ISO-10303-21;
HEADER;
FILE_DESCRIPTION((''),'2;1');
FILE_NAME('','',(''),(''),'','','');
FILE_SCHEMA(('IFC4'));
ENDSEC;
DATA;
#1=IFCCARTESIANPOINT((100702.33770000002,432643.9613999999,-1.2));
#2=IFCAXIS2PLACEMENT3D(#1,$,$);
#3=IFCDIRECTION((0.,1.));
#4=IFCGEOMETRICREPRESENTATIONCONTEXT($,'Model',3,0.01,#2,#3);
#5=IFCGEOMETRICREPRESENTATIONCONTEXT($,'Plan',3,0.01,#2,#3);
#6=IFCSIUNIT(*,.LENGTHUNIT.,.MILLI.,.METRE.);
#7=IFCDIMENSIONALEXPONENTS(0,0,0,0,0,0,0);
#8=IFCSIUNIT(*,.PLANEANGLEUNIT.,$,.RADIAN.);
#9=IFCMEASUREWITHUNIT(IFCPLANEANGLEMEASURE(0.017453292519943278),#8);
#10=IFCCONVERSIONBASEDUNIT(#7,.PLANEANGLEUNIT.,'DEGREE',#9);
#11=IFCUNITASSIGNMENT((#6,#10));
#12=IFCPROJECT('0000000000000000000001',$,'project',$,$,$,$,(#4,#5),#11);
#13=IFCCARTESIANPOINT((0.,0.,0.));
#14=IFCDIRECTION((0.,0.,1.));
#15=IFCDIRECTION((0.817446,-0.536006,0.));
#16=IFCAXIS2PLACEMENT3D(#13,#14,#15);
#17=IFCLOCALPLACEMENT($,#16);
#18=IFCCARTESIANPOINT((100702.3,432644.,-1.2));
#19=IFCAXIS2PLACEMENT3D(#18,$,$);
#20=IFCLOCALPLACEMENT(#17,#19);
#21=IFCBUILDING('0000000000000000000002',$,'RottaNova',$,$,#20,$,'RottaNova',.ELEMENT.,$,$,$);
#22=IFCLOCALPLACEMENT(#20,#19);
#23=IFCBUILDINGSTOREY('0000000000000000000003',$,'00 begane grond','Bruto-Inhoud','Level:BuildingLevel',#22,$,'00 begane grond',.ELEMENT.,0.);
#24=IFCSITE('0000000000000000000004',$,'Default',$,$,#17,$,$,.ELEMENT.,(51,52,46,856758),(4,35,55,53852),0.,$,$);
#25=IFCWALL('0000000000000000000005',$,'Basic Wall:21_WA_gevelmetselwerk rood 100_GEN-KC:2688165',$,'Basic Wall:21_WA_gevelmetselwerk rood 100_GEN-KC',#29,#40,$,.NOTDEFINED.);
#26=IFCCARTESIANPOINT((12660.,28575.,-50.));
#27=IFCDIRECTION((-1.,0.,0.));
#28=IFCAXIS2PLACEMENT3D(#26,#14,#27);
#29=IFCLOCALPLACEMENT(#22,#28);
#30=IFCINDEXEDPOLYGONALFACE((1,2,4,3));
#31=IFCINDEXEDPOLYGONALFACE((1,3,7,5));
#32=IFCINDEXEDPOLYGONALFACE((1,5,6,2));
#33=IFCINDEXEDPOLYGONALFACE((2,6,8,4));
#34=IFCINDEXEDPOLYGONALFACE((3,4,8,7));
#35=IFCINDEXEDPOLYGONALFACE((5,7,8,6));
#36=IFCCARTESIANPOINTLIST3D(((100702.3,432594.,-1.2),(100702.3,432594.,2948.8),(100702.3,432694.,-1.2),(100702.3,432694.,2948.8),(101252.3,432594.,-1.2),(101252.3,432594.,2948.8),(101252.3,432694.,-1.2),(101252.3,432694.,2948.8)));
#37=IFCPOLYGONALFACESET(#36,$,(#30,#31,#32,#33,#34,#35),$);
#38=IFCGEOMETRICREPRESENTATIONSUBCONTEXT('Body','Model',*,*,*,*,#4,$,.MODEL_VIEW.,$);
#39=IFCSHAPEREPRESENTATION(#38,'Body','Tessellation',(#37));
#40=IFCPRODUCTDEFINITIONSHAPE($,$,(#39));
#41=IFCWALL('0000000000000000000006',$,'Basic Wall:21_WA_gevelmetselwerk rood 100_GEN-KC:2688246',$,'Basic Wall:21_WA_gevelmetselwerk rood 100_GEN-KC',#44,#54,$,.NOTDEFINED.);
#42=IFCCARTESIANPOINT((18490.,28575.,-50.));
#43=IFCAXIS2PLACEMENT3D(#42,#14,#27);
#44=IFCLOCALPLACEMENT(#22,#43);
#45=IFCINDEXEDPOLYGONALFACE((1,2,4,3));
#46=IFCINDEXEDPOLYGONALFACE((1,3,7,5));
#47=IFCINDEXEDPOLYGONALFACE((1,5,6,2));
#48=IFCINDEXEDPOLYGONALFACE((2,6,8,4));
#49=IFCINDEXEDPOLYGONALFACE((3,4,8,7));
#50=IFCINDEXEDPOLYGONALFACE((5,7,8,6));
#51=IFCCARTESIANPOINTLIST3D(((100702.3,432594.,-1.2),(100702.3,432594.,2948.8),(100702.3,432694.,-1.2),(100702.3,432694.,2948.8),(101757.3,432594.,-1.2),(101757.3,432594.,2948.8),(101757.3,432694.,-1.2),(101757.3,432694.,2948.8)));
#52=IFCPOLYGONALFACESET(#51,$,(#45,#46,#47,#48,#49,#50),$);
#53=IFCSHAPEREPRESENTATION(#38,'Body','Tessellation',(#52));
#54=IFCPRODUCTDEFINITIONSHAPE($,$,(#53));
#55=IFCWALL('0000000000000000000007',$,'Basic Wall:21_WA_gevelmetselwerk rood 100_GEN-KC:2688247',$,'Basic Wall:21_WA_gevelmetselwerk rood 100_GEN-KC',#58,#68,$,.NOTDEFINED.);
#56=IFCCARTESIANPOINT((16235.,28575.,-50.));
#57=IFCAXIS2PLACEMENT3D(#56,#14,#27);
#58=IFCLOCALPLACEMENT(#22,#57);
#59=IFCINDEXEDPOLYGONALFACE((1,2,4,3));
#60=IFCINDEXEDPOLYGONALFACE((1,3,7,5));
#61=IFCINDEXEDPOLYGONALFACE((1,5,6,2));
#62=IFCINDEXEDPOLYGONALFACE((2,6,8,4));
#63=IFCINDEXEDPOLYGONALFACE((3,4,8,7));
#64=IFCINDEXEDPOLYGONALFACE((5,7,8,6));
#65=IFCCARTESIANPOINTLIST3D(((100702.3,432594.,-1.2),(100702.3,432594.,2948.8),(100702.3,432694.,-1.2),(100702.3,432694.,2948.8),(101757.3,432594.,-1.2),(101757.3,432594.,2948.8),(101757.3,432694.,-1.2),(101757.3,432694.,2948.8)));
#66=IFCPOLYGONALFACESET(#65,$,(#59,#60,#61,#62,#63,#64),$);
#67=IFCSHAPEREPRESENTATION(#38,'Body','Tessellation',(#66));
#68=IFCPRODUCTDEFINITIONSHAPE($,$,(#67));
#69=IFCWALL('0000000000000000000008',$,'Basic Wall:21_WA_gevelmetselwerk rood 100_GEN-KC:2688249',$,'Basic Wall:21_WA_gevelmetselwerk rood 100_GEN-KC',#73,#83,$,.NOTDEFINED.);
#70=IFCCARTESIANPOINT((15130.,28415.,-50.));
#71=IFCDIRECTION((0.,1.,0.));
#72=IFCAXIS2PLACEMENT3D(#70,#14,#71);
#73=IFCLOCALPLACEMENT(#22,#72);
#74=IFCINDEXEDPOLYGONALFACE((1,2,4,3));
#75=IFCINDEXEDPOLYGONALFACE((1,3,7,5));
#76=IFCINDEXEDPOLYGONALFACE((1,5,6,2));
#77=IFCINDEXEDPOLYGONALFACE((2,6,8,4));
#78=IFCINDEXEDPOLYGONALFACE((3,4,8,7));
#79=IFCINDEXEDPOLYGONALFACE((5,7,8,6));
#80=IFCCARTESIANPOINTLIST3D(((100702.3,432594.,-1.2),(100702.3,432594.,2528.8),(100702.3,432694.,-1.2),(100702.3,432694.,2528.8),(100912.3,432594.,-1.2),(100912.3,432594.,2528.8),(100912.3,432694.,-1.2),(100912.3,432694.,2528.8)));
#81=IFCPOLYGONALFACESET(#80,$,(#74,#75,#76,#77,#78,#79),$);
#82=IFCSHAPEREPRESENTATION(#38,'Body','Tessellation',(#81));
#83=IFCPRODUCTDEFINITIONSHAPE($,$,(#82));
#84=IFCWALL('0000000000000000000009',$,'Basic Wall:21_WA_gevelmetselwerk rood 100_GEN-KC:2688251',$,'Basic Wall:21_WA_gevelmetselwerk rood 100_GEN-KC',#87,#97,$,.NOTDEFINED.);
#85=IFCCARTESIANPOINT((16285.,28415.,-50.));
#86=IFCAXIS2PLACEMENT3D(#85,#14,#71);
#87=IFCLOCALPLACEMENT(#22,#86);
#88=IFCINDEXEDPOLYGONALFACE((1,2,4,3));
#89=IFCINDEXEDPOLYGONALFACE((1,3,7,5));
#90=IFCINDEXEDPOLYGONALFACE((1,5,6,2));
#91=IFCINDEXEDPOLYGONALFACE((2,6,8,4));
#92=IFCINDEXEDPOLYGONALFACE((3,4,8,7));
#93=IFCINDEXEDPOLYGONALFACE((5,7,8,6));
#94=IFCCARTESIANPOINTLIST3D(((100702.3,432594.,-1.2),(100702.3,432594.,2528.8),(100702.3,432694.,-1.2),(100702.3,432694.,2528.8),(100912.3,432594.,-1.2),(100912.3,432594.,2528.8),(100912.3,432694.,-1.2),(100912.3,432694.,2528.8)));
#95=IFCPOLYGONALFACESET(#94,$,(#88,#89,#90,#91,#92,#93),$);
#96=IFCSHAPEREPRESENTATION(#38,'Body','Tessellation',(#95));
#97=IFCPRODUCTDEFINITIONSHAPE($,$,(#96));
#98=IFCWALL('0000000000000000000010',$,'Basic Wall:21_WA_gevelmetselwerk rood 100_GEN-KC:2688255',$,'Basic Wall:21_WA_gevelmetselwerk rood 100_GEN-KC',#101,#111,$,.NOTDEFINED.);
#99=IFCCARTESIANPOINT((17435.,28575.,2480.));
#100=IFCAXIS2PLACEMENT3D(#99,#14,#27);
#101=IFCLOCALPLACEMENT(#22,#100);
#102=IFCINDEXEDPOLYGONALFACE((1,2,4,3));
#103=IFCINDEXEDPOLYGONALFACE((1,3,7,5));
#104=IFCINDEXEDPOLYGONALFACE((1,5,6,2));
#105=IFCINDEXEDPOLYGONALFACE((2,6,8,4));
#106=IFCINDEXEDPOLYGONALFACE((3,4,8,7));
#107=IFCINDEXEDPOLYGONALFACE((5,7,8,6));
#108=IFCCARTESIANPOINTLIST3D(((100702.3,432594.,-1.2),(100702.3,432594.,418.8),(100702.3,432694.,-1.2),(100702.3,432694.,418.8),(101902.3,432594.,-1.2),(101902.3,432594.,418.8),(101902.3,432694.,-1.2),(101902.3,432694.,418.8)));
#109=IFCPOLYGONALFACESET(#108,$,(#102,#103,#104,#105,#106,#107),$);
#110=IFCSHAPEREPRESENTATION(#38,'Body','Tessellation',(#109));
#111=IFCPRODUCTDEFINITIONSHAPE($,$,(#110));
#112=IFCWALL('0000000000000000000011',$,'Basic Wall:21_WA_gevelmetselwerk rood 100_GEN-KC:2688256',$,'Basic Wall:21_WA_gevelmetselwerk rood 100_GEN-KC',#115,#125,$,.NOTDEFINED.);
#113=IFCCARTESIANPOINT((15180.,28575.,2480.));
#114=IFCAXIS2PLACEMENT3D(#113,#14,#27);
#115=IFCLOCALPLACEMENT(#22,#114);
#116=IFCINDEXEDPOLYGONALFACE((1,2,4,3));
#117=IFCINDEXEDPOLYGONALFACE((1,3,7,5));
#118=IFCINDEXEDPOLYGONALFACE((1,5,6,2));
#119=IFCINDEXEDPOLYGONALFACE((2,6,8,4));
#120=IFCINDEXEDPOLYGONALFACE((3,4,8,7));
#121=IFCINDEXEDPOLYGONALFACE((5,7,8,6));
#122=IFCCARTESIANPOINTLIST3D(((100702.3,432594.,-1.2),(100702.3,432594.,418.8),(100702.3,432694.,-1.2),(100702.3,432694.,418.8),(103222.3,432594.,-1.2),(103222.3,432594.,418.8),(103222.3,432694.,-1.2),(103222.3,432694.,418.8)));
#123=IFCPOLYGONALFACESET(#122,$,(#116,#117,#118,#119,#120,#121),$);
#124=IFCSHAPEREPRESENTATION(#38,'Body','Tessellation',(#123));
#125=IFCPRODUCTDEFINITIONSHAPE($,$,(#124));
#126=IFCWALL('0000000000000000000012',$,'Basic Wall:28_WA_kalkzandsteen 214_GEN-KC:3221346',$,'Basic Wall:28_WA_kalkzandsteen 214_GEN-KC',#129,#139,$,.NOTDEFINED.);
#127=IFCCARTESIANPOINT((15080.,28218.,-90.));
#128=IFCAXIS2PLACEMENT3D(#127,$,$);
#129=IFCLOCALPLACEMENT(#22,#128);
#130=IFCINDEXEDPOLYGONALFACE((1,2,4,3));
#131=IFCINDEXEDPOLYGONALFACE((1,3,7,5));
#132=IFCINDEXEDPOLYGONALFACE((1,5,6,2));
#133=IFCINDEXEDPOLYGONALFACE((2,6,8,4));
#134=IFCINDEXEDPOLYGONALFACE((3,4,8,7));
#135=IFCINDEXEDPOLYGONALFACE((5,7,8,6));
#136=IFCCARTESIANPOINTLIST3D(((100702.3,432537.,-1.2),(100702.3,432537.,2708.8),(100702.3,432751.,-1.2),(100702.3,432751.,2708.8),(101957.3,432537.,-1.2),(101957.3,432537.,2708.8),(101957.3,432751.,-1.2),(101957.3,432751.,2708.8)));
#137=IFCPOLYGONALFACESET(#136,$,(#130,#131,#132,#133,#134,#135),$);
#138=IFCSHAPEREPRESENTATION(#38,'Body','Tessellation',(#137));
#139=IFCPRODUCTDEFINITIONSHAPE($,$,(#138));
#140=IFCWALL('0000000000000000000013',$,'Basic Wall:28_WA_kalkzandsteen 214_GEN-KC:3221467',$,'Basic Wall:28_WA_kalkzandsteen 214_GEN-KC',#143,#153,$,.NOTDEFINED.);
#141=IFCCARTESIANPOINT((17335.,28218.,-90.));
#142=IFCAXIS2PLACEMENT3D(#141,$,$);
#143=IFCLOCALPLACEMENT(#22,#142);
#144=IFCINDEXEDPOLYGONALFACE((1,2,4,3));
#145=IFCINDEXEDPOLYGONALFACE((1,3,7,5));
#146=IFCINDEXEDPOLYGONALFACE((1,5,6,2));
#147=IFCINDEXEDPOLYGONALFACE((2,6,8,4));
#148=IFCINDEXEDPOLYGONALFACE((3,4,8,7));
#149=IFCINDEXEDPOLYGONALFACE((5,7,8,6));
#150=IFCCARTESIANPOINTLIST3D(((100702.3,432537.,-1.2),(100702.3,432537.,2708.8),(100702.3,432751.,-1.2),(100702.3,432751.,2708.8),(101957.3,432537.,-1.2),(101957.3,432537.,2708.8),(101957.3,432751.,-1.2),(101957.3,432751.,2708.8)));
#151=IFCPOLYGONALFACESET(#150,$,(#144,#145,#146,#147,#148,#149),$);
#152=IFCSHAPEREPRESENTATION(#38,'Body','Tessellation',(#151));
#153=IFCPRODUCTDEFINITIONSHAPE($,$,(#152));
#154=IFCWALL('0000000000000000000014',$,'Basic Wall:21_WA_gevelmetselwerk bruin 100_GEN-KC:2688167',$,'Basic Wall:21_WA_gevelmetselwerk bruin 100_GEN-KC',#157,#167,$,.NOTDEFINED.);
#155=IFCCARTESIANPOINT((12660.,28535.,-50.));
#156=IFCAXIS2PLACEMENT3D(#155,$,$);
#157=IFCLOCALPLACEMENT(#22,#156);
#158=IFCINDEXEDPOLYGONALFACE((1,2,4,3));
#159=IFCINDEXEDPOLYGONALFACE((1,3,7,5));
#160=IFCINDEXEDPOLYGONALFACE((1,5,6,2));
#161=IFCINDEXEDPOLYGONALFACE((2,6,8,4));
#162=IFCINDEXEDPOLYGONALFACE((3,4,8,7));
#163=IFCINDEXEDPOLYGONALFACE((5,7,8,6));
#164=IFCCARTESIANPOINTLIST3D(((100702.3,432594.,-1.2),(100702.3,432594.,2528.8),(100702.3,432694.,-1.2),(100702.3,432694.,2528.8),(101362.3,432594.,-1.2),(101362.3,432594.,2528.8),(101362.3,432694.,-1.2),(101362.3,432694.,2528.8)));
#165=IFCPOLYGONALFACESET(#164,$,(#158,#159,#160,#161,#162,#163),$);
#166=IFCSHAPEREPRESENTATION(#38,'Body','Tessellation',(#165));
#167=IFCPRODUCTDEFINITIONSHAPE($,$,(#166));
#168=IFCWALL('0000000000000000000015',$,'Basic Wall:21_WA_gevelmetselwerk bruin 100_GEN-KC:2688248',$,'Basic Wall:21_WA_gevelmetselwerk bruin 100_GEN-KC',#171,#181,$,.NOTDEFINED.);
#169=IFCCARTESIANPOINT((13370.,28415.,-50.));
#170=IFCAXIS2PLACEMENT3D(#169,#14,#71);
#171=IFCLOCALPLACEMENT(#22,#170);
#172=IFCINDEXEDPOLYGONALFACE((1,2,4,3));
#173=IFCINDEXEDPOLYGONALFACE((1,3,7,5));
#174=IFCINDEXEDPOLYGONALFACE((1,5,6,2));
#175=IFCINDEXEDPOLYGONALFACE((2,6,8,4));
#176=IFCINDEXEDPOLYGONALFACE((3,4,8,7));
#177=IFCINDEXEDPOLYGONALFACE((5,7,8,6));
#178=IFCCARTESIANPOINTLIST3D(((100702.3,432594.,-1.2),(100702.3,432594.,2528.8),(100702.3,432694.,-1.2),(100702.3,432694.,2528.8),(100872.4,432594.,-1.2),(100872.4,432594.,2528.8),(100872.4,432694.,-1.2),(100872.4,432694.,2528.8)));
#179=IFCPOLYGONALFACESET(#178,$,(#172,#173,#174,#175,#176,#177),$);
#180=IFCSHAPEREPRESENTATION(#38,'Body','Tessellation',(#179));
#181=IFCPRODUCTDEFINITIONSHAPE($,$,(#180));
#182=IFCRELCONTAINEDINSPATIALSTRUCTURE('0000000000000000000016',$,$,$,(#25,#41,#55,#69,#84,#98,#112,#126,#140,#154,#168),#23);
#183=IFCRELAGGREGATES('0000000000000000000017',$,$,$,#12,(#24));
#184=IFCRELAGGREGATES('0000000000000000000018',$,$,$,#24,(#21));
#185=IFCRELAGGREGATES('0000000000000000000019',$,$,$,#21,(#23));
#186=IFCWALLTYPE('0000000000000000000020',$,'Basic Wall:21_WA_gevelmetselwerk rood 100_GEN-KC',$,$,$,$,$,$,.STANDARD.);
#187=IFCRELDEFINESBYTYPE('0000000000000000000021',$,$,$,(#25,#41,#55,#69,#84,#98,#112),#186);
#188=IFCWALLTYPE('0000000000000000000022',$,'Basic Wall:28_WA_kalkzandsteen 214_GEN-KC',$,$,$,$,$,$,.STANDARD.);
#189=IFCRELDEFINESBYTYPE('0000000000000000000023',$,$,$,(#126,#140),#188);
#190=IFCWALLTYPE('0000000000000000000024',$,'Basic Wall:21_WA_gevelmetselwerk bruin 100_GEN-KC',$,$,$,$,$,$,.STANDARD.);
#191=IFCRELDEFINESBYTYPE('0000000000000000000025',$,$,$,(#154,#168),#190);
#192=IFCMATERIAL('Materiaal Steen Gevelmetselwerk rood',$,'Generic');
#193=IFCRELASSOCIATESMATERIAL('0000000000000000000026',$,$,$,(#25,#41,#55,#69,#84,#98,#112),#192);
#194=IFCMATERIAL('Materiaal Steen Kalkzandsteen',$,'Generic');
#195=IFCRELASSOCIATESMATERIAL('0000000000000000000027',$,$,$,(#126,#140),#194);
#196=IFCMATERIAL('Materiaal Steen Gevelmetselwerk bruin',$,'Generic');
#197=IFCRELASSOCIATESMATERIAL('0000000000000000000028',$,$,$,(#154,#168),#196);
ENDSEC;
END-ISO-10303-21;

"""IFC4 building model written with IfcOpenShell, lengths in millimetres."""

from ifc_helpers import new_model, entity, si_unit, converted_unit, direction, frame, place, context, subcontext, project, spatial, indexed_curve, outline, extrude, material, type_object, element, save


model = new_model("IFC4")

# Units and contexts
model_context = context("Model", 3, precision=0.01, world=frame((100702.33770000002, 432643.9613999999, -1.2)), true_north=direction((0.0, 1.0)))
plan_context = context("Plan", 3, precision=0.01, world=frame((100702.33770000002, 432643.9613999999, -1.2)), true_north=direction((0.0, 1.0)))
body_context = subcontext(model_context, "Body", "Model", "MODEL_VIEW")
ifc_project = project(units=[si_unit("LENGTHUNIT", "METRE", prefix="MILLI"), converted_unit("PLANEANGLEUNIT", "DEGREE", entity("IfcPlaneAngleMeasure", 0.017453292519943278), si_unit("PLANEANGLEUNIT", "RADIAN"), dimensions=[0, 0, 0, 0, 0, 0, 0])], contexts=[model_context, plan_context])

# Site, building, storey
site_placement = place(None, frame((0.0, 0.0, 0.0), z_axis=(0.0, 0.0, 1.0), x_axis=(0.817446, -0.536006, 0.0)))
site = spatial("IfcSite", under=ifc_project, at=site_placement, Name="Default", CompositionType="ELEMENT", RefLatitude=(51, 52, 46, 856758), RefLongitude=(4, 35, 55, 53852), RefElevation=0.0)
building_placement = place(site_placement, frame((100702.3, 432644.0, -1.2)))
building = spatial("IfcBuilding", under=site, at=building_placement, Name="RottaNova", LongName="RottaNova", CompositionType="ELEMENT")
storey_placement = place(building_placement, frame((100702.3, 432644.0, -1.2)))
storey = spatial("IfcBuildingStorey", under=building, at=storey_placement, Name="00 begane grond", Description="Bruto-Inhoud", ObjectType="Level:BuildingLevel", LongName="00 begane grond", CompositionType="ELEMENT", Elevation=0.0)

# Walls
ifc_material_1 = material(Name="Materiaal Steen Gevelmetselwerk rood", Category="Generic")
wall_type_1 = type_object("IfcWallType", Name="Basic Wall:21_WA_gevelmetselwerk rood 100_GEN-KC", PredefinedType="STANDARD")
wall_1_placement = place(storey_placement, frame((12660.0, 28575.0, -50.0), z_axis=(0.0, 0.0, 1.0), x_axis=(-1.0, 0.0, 0.0)))
element("IfcWall", 1, at=wall_1_placement, inside=storey, type_object=wall_type_1, material=ifc_material_1, Name="Basic Wall:21_WA_gevelmetselwerk rood 100_GEN-KC:2688165", ObjectType="Basic Wall:21_WA_gevelmetselwerk rood 100_GEN-KC", PredefinedType="NOTDEFINED", context=body_context, shape_type="SweptSolid", body=[
    extrude(outline(indexed_curve([(550.0, 50.0), (0.0, 50.0), (0.0, -50.0), (550.0, -50.0), (550.0, 50.0)], self_intersect=False)), frame((100702.3, 432644.0, -1.2)), (0.0, 0.0, 1.0), 2950.0),
])
wall_2_placement = place(storey_placement, frame((18490.0, 28575.0, -50.0), z_axis=(0.0, 0.0, 1.0), x_axis=(-1.0, 0.0, 0.0)))
element("IfcWall", 2, at=wall_2_placement, inside=storey, type_object=wall_type_1, material=ifc_material_1, Name="Basic Wall:21_WA_gevelmetselwerk rood 100_GEN-KC:2688246", ObjectType="Basic Wall:21_WA_gevelmetselwerk rood 100_GEN-KC", PredefinedType="NOTDEFINED", context=body_context, shape_type="SweptSolid", body=[
    extrude(outline(indexed_curve([(1055.0, 50.0), (0.0, 50.0), (0.0, -50.0), (1055.0, -50.0), (1055.0, 50.0)], self_intersect=False)), frame((100702.3, 432644.0, -1.2)), (0.0, 0.0, 1.0), 2950.0),
])
wall_3_placement = place(storey_placement, frame((16235.0, 28575.0, -50.0), z_axis=(0.0, 0.0, 1.0), x_axis=(-1.0, 0.0, 0.0)))
element("IfcWall", 3, at=wall_3_placement, inside=storey, type_object=wall_type_1, material=ifc_material_1, Name="Basic Wall:21_WA_gevelmetselwerk rood 100_GEN-KC:2688247", ObjectType="Basic Wall:21_WA_gevelmetselwerk rood 100_GEN-KC", PredefinedType="NOTDEFINED", context=body_context, shape_type="SweptSolid", body=[
    extrude(outline(indexed_curve([(1055.0, 50.0), (0.0, 50.0), (0.0, -50.0), (1055.0, -50.0), (1055.0, 50.0)], self_intersect=False)), frame((100702.3, 432644.0, -1.2)), (0.0, 0.0, 1.0), 2950.0),
])
wall_4_placement = place(storey_placement, frame((15130.0, 28415.0, -50.0), z_axis=(0.0, 0.0, 1.0), x_axis=(0.0, 1.0, 0.0)))
element("IfcWall", 4, at=wall_4_placement, inside=storey, type_object=wall_type_1, material=ifc_material_1, Name="Basic Wall:21_WA_gevelmetselwerk rood 100_GEN-KC:2688249", ObjectType="Basic Wall:21_WA_gevelmetselwerk rood 100_GEN-KC", PredefinedType="NOTDEFINED", context=body_context, shape_type="SweptSolid", body=[
    extrude(outline(indexed_curve([(210.0, 50.0), (0.0, 50.0), (0.0, -50.0), (210.0, -50.0), (210.0, 50.0)], self_intersect=False)), frame((100702.3, 432644.0, -1.2)), (0.0, 0.0, 1.0), 2530.0),
])
wall_5_placement = place(storey_placement, frame((16285.0, 28415.0, -50.0), z_axis=(0.0, 0.0, 1.0), x_axis=(0.0, 1.0, 0.0)))
element("IfcWall", 5, at=wall_5_placement, inside=storey, type_object=wall_type_1, material=ifc_material_1, Name="Basic Wall:21_WA_gevelmetselwerk rood 100_GEN-KC:2688251", ObjectType="Basic Wall:21_WA_gevelmetselwerk rood 100_GEN-KC", PredefinedType="NOTDEFINED", context=body_context, shape_type="SweptSolid", body=[
    extrude(outline(indexed_curve([(210.0, 50.0), (0.0, 50.0), (0.0, -50.0), (210.0, -50.0), (210.0, 50.0)], self_intersect=False)), frame((100702.3, 432644.0, -1.2)), (0.0, 0.0, 1.0), 2530.0),
])
wall_6_placement = place(storey_placement, frame((17435.0, 28575.0, 2480.0), z_axis=(0.0, 0.0, 1.0), x_axis=(-1.0, 0.0, 0.0)))
element("IfcWall", 6, at=wall_6_placement, inside=storey, type_object=wall_type_1, material=ifc_material_1, Name="Basic Wall:21_WA_gevelmetselwerk rood 100_GEN-KC:2688255", ObjectType="Basic Wall:21_WA_gevelmetselwerk rood 100_GEN-KC", PredefinedType="NOTDEFINED", context=body_context, shape_type="SweptSolid", body=[
    extrude(outline(indexed_curve([(1200.0, 50.0), (0.0, 50.0), (0.0, -50.0), (1200.0, -50.0), (1200.0, 50.0)], self_intersect=False)), frame((100702.3, 432644.0, -1.2)), (0.0, 0.0, 1.0), 420.0),
])
wall_7_placement = place(storey_placement, frame((15180.0, 28575.0, 2480.0), z_axis=(0.0, 0.0, 1.0), x_axis=(-1.0, 0.0, 0.0)))
element("IfcWall", 7, at=wall_7_placement, inside=storey, type_object=wall_type_1, material=ifc_material_1, Name="Basic Wall:21_WA_gevelmetselwerk rood 100_GEN-KC:2688256", ObjectType="Basic Wall:21_WA_gevelmetselwerk rood 100_GEN-KC", PredefinedType="NOTDEFINED", context=body_context, shape_type="SweptSolid", body=[
    extrude(outline(indexed_curve([(2520.0, 50.0), (0.0, 50.0), (0.0, -50.0), (2520.0, -50.0), (2520.0, 50.0)], self_intersect=False)), frame((100702.3, 432644.0, -1.2)), (0.0, 0.0, 1.0), 420.0),
])
ifc_material_2 = material(Name="Materiaal Steen Kalkzandsteen", Category="Generic")
wall_type_2 = type_object("IfcWallType", Name="Basic Wall:28_WA_kalkzandsteen 214_GEN-KC", PredefinedType="STANDARD")
wall_8_placement = place(storey_placement, frame((15080.0, 28218.0, -90.0)))
element("IfcWall", 8, at=wall_8_placement, inside=storey, type_object=wall_type_2, material=ifc_material_2, Name="Basic Wall:28_WA_kalkzandsteen 214_GEN-KC:3221346", ObjectType="Basic Wall:28_WA_kalkzandsteen 214_GEN-KC", PredefinedType="NOTDEFINED", context=body_context, shape_type="SweptSolid", body=[
    extrude(outline(indexed_curve([(1255.0, 107.0), (0.0, 107.0), (0.0, -107.0), (1255.0, -107.0), (1255.0, 107.0)], self_intersect=False)), frame((100702.3, 432644.0, -1.2)), (0.0, 0.0, 1.0), 2710.0),
])
wall_9_placement = place(storey_placement, frame((17335.0, 28218.0, -90.0)))
element("IfcWall", 9, at=wall_9_placement, inside=storey, type_object=wall_type_2, material=ifc_material_2, Name="Basic Wall:28_WA_kalkzandsteen 214_GEN-KC:3221467", ObjectType="Basic Wall:28_WA_kalkzandsteen 214_GEN-KC", PredefinedType="NOTDEFINED", context=body_context, shape_type="SweptSolid", body=[
    extrude(outline(indexed_curve([(1255.0, 107.0), (0.0, 107.0), (0.0, -107.0), (1255.0, -107.0), (1255.0, 107.0)], self_intersect=False)), frame((100702.3, 432644.0, -1.2)), (0.0, 0.0, 1.0), 2710.0),
])
ifc_material_3 = material(Name="Materiaal Steen Gevelmetselwerk bruin", Category="Generic")
wall_type_3 = type_object("IfcWallType", Name="Basic Wall:21_WA_gevelmetselwerk bruin 100_GEN-KC", PredefinedType="STANDARD")
wall_10_placement = place(storey_placement, frame((12660.0, 28535.0, -50.0)))
element("IfcWall", 10, at=wall_10_placement, inside=storey, type_object=wall_type_3, material=ifc_material_3, Name="Basic Wall:21_WA_gevelmetselwerk bruin 100_GEN-KC:2688167", ObjectType="Basic Wall:21_WA_gevelmetselwerk bruin 100_GEN-KC", PredefinedType="NOTDEFINED", context=body_context, shape_type="SweptSolid", body=[
    extrude(outline(indexed_curve([(660.0, 50.0), (0.0, 50.0), (0.0, -50.0), (660.0, -50.0), (660.0, 50.0)], self_intersect=False)), frame((100702.3, 432644.0, -1.2)), (0.0, 0.0, 1.0), 2530.0),
])
wall_11_placement = place(storey_placement, frame((13370.0, 28415.0, -50.0), z_axis=(0.0, 0.0, 1.0), x_axis=(0.0, 1.0, 0.0)))
element("IfcWall", 11, at=wall_11_placement, inside=storey, type_object=wall_type_3, material=ifc_material_3, Name="Basic Wall:21_WA_gevelmetselwerk bruin 100_GEN-KC:2688248", ObjectType="Basic Wall:21_WA_gevelmetselwerk bruin 100_GEN-KC", PredefinedType="NOTDEFINED", context=body_context, shape_type="SweptSolid", body=[
    extrude(outline(indexed_curve([(170.0, 50.0), (0.0, 50.0), (0.0, -50.0), (170.0, -50.0), (170.0, 50.0)], self_intersect=False)), frame((100702.3, 432644.0, -1.2)), (0.0, 0.0, 1.0), 2530.0),
])

save(model, "model.ifc")
